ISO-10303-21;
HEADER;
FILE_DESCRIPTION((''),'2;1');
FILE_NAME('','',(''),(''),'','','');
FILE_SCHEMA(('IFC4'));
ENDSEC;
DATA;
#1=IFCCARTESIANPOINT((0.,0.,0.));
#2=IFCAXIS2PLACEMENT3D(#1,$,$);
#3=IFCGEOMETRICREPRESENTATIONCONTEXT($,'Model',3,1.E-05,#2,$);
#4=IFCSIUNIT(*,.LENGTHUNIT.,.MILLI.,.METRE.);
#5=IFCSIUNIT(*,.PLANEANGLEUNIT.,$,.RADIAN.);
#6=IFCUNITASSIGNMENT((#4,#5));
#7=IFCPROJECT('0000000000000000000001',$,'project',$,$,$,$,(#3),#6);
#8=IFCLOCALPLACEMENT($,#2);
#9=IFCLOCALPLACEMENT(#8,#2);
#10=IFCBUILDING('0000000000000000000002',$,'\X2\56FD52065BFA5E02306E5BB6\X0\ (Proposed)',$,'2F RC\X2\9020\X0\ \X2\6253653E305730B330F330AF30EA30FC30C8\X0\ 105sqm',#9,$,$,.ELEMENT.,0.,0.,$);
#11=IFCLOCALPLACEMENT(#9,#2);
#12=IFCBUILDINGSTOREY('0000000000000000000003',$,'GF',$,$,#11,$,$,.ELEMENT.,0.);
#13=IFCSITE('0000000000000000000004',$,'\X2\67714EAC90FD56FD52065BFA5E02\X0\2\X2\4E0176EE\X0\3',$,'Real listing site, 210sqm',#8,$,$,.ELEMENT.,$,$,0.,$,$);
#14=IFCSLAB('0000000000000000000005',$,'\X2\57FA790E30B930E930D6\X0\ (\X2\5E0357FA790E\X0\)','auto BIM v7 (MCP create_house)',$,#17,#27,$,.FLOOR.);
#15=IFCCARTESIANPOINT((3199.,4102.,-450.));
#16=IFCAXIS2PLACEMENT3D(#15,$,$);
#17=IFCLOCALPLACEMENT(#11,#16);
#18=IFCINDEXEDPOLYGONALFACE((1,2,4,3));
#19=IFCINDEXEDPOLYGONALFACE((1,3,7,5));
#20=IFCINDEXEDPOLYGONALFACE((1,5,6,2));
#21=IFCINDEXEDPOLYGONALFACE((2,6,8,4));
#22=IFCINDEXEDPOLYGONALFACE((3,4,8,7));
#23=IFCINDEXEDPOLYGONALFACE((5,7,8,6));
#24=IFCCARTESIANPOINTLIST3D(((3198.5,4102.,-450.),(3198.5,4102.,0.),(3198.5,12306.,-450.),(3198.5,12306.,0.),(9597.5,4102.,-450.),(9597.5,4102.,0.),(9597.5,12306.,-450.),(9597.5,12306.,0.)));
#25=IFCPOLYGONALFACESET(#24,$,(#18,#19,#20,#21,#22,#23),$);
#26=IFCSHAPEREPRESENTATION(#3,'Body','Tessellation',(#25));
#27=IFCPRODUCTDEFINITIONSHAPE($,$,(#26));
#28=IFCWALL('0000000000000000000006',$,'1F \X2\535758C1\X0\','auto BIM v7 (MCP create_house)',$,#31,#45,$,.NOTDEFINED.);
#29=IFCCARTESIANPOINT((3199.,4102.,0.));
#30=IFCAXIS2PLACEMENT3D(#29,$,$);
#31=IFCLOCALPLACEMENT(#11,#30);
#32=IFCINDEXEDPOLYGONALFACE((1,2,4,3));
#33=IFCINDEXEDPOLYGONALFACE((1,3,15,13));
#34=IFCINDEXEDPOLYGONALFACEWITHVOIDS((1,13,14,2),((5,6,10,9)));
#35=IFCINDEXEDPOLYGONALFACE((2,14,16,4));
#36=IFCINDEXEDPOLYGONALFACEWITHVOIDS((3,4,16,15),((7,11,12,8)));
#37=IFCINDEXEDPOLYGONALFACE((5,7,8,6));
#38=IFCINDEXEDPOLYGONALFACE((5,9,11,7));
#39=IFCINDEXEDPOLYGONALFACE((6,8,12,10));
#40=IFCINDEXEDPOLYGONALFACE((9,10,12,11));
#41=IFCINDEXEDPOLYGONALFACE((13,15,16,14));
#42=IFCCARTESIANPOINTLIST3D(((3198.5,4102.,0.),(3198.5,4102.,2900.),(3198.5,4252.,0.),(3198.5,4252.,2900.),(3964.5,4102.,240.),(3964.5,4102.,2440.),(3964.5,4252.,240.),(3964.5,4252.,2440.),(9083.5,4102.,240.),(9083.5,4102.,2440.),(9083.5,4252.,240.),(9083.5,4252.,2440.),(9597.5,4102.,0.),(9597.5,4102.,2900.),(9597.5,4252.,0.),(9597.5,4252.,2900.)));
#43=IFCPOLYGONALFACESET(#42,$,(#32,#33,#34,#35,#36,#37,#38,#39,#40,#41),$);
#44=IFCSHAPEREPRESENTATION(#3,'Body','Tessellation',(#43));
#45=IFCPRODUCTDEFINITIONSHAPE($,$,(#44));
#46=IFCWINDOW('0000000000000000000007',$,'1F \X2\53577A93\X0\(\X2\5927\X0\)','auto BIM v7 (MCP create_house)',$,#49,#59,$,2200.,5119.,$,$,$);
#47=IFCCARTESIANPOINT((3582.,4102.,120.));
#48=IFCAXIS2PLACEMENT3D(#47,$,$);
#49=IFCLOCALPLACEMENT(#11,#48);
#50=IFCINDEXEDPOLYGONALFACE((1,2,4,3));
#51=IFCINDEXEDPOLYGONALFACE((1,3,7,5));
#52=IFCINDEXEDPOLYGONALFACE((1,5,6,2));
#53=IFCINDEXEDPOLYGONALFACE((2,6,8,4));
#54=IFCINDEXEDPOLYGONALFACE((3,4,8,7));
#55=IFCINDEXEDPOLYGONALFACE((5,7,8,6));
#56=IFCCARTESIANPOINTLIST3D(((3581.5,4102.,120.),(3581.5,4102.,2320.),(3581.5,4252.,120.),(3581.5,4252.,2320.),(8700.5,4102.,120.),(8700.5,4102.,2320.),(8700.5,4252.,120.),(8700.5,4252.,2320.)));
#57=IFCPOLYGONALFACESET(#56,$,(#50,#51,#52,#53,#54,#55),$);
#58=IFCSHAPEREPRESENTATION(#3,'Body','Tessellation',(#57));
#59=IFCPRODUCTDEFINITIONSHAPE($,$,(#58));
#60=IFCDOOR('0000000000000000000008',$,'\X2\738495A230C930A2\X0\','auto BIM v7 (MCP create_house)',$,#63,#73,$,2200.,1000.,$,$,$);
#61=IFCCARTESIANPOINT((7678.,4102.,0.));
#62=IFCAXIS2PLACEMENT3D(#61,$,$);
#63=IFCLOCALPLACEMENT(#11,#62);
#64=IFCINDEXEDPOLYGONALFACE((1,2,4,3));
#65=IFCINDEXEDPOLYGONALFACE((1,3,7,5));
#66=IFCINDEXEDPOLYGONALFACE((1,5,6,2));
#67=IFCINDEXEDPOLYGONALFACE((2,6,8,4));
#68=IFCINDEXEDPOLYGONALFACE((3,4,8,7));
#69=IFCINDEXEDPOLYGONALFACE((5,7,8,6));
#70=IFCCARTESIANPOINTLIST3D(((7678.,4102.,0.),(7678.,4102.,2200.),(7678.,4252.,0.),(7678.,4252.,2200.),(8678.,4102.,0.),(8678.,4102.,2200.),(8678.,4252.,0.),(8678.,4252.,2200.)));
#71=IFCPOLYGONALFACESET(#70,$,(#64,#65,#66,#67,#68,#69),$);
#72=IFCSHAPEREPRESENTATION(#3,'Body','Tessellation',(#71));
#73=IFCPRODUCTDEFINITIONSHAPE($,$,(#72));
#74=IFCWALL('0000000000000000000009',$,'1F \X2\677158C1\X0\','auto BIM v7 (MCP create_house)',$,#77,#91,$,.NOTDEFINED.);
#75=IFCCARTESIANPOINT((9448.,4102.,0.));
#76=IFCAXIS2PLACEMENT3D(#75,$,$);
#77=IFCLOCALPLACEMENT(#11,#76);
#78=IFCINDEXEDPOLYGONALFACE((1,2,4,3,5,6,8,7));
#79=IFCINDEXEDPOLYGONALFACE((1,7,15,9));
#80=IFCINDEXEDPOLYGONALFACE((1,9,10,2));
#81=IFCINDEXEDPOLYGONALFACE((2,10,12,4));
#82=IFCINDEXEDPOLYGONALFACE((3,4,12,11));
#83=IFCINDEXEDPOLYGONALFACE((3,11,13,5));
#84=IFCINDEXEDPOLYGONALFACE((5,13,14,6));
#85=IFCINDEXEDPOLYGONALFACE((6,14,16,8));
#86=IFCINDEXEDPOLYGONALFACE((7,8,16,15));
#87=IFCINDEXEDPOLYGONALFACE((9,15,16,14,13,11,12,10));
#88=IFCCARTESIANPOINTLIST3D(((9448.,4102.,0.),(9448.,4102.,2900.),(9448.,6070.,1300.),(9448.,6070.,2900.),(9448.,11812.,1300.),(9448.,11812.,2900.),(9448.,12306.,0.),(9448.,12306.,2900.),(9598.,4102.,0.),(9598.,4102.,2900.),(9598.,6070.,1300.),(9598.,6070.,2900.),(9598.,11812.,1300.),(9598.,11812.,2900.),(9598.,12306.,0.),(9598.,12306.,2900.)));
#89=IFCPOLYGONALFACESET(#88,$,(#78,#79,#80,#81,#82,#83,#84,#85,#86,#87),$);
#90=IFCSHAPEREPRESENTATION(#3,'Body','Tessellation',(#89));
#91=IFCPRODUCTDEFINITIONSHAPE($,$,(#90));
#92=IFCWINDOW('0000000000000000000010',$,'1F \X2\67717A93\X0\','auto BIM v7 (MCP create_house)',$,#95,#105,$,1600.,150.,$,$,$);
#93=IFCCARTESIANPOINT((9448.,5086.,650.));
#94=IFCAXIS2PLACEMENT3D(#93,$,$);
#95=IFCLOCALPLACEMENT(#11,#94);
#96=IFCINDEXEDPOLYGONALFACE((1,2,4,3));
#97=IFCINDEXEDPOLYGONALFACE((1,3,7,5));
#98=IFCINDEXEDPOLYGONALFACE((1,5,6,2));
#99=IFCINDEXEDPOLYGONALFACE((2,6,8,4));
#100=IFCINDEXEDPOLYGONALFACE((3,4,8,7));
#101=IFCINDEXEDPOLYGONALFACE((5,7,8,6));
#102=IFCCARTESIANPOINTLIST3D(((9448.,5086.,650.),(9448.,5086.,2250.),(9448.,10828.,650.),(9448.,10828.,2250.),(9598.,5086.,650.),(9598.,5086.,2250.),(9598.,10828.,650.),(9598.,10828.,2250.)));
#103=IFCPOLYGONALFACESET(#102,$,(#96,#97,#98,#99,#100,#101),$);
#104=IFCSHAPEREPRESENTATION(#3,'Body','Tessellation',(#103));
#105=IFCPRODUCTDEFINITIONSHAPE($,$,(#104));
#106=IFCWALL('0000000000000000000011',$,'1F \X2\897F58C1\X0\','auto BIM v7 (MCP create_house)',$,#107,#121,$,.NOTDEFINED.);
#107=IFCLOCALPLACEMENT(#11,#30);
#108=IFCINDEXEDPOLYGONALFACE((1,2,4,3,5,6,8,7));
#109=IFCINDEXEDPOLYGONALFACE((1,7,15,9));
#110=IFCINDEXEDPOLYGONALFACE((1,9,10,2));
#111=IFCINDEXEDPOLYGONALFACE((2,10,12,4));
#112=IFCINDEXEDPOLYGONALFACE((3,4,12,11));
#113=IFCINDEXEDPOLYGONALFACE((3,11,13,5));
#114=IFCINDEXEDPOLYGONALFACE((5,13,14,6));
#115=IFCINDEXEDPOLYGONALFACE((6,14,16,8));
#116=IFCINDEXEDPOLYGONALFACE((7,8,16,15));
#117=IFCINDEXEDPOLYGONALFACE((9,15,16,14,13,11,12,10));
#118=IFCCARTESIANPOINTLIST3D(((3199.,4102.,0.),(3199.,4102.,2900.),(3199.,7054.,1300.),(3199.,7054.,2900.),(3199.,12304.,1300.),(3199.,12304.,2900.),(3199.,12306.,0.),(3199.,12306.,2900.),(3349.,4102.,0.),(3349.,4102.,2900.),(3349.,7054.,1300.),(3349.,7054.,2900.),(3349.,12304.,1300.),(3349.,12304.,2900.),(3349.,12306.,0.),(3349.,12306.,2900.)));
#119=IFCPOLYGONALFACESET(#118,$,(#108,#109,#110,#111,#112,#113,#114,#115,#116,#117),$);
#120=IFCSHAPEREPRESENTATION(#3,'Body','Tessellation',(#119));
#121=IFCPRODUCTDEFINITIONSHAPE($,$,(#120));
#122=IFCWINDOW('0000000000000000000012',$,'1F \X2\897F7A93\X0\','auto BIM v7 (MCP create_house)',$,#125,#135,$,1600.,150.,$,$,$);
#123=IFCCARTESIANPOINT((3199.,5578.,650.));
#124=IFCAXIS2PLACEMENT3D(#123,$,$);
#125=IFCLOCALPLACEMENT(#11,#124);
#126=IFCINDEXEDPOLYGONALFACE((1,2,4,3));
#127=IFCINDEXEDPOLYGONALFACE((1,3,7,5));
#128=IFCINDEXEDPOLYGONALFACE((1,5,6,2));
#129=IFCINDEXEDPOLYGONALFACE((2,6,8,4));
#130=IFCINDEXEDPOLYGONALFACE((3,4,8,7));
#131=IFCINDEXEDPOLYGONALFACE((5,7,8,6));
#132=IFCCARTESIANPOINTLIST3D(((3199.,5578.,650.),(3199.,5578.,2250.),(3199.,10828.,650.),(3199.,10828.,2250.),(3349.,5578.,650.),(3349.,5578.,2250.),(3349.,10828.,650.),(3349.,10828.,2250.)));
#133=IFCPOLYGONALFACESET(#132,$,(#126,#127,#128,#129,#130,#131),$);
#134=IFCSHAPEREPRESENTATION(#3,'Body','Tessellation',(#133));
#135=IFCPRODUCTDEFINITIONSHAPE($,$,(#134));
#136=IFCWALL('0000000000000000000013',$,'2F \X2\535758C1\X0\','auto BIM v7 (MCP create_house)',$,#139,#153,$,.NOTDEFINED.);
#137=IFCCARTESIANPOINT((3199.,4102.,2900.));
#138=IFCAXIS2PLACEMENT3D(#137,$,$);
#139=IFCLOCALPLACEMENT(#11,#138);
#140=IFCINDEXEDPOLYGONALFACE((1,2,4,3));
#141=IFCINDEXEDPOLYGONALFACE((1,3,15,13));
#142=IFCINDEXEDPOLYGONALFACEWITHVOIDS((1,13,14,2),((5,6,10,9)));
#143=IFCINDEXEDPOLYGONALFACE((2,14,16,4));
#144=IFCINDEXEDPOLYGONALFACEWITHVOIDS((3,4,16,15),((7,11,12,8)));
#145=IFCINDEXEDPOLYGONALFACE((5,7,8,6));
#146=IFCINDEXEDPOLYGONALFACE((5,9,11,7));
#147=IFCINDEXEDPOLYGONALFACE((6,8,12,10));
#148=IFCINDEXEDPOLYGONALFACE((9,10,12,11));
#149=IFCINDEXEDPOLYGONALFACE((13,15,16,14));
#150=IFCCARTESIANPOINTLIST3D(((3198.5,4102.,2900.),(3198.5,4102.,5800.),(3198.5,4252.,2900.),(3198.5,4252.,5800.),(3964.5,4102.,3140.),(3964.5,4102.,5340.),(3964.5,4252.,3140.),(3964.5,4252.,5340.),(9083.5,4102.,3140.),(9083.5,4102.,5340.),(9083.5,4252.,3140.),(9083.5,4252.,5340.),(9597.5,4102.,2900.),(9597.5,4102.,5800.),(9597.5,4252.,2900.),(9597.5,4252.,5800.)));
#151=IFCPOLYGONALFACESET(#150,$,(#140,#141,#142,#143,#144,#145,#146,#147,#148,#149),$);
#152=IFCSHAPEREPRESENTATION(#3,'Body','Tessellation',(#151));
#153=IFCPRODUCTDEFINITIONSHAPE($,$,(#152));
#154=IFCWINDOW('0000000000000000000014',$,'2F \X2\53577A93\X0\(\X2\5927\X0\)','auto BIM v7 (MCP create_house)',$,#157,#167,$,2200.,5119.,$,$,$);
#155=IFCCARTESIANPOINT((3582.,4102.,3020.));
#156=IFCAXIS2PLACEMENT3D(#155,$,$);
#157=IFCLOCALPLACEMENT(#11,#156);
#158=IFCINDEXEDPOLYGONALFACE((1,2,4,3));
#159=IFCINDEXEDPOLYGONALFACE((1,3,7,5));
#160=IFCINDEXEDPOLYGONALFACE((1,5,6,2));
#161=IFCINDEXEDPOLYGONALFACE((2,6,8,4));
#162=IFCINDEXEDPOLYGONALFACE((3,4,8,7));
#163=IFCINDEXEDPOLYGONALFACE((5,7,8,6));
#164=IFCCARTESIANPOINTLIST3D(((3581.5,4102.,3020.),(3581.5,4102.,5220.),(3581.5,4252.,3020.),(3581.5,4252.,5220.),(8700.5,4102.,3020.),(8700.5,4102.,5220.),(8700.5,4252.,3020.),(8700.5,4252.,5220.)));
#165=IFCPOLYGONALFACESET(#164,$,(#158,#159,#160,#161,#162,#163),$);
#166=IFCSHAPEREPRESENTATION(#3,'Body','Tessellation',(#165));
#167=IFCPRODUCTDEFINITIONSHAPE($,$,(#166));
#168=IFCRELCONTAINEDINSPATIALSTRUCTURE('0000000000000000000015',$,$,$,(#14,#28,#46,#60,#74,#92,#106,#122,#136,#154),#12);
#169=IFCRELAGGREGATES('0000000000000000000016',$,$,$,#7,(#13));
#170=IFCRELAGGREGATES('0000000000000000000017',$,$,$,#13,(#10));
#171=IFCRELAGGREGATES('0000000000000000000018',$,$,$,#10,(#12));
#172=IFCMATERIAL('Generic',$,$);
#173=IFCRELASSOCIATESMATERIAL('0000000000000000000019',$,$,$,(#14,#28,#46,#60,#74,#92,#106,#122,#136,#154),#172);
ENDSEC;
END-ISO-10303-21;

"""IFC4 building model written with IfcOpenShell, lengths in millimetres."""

from ifc_helpers import new_model, si_unit, frame, frame_2d, origin, place, context, project, spatial, rectangle, extrude, material, element, fill, save


model = new_model("IFC4")

# Units and contexts
model_context = context("Model", 3, precision=1e-05, world=origin())
ifc_project = project(units=[si_unit("LENGTHUNIT", "METRE", prefix="MILLI"), si_unit("PLANEANGLEUNIT", "RADIAN")], contexts=[model_context])

# Site, building, storey
site_placement = place(None, origin())
site = spatial("IfcSite", under=ifc_project, at=site_placement, Name="東京都国分寺市2丁目3", ObjectType="Real listing site, 210sqm", CompositionType="ELEMENT", RefElevation=0.0)
building_placement = place(site_placement, origin())
building = spatial("IfcBuilding", under=site, at=building_placement, Name="国分寺市の家 (Proposed)", ObjectType="2F RC造 打放しコンクリート 105sqm", CompositionType="ELEMENT", ElevationOfRefHeight=0.0, ElevationOfTerrain=0.0)
storey_placement = place(building_placement, origin())
storey = spatial("IfcBuildingStorey", under=building, at=storey_placement, Name="GF", CompositionType="ELEMENT", Elevation=0.0)

# Slab
ifc_material = material(Name="Generic")
slab_1_placement = place(storey_placement, frame((3199.0, 4102.0, -450.0)))
element("IfcSlab", 1, at=slab_1_placement, inside=storey, material=ifc_material, Name="基礎スラブ (布基礎)", Description="auto BIM v7 (MCP create_house)", PredefinedType="FLOOR", context=model_context, shape_type="SweptSolid", body=[
    extrude(rectangle(XDim=6399.0, YDim=8204.0, at=frame_2d((3199.0, 4102.0))), frame((3199.0, 4102.0, -450.0)), (0.0, 0.0, 1.0), 450.0),
])

# Wall, openings, window, door
wall_1_placement = place(storey_placement, frame((3199.0, 4102.0, 0.0)))
wall_1 = element("IfcWall", 2, at=wall_1_placement, inside=storey, material=ifc_material, Name="1F 南壁", Description="auto BIM v7 (MCP create_house)", PredefinedType="NOTDEFINED", context=model_context, shape_type="SweptSolid", body=[
    extrude(rectangle(XDim=6399.0, YDim=150.0, at=frame_2d((3199.0, 75.0))), frame((3199.0, 4102.0, 0.0)), (0.0, 0.0, 1.0), 2900.0),
])
opening_1_placement = place(storey_placement, frame((3582.0, 4102.0, 120.0)))
opening_1 = element("IfcOpeningElement", 3, at=opening_1_placement, cuts=wall_1, PredefinedType="NOTDEFINED", context=model_context, shape_type="SweptSolid", body=[
    extrude(rectangle(XDim=5119.0, YDim=150.0, at=frame_2d((2559.0, 75.0))), frame((3582.0, 4102.0, 120.0)), (0.0, 0.0, 1.0), 2200.0),
])
opening_2_placement = place(storey_placement, frame((7678.0, 4102.0, 0.0)))
opening_2 = element("IfcOpeningElement", 4, at=opening_2_placement, cuts=wall_1, PredefinedType="NOTDEFINED", context=model_context, shape_type="SweptSolid", body=[
    extrude(rectangle(XDim=1000.0, YDim=150.0, at=frame_2d((500.0, 75.0))), frame((7678.0, 4102.0, 0.0)), (0.0, 0.0, 1.0), 2200.0),
])
window_1_placement = place(storey_placement, frame((3582.0, 4102.0, 120.0)))
window_1 = element("IfcWindow", 5, at=window_1_placement, inside=storey, material=ifc_material, Name="1F 南窓(大)", Description="auto BIM v7 (MCP create_house)", OverallHeight=2200.0, OverallWidth=5119.0, context=model_context, shape_type="SweptSolid", body=[
    extrude(rectangle(XDim=5119.0, YDim=150.0, at=frame_2d((2559.0, 75.0))), frame((3582.0, 4102.0, 120.0)), (0.0, 0.0, 1.0), 2200.0),
])
fill(opening_1, window_1)
door_placement = place(storey_placement, frame((7678.0, 4102.0, 0.0)))
door = element("IfcDoor", 6, at=door_placement, inside=storey, material=ifc_material, Name="玄関ドア", Description="auto BIM v7 (MCP create_house)", OverallHeight=2200.0, OverallWidth=1000.0, context=model_context, shape_type="SweptSolid", body=[
    extrude(rectangle(XDim=1000.0, YDim=150.0, at=frame_2d((500.0, 75.0))), frame((7678.0, 4102.0, 0.0)), (0.0, 0.0, 1.0), 2200.0),
])
fill(opening_2, door)

# Walls, openings, windows
wall_2_placement = place(storey_placement, frame((9448.0, 4102.0, 0.0)))
wall_2 = element("IfcWall", 7, at=wall_2_placement, inside=storey, material=ifc_material, Name="1F 東壁", Description="auto BIM v7 (MCP create_house)", PredefinedType="NOTDEFINED", context=model_context, shape_type="SweptSolid", body=[
    extrude(rectangle(XDim=150.0, YDim=8204.0, at=frame_2d((75.0, 4102.0))), frame((9448.0, 4102.0, 0.0)), (0.0, 0.0, 1.0), 2900.0),
])
opening_3_placement = place(storey_placement, frame((9448.0, 5086.0, 650.0)))
opening_3 = element("IfcOpeningElement", 8, at=opening_3_placement, cuts=wall_2, PredefinedType="NOTDEFINED", context=model_context, shape_type="SweptSolid", body=[
    extrude(rectangle(XDim=150.0, YDim=5742.0, at=frame_2d((75.0, 2871.0))), frame((9448.0, 5086.0, 650.0)), (0.0, 0.0, 1.0), 1600.0),
])
window_2_placement = place(storey_placement, frame((9448.0, 5086.0, 650.0)))
window_2 = element("IfcWindow", 9, at=window_2_placement, inside=storey, material=ifc_material, Name="1F 東窓", Description="auto BIM v7 (MCP create_house)", OverallHeight=1600.0, OverallWidth=150.0, context=model_context, shape_type="SweptSolid", body=[
    extrude(rectangle(XDim=150.0, YDim=5742.0, at=frame_2d((75.0, 2871.0))), frame((9448.0, 5086.0, 650.0)), (0.0, 0.0, 1.0), 1600.0),
])
fill(opening_3, window_2)
wall_3_placement = place(storey_placement, frame((3199.0, 4102.0, 0.0)))
wall_3 = element("IfcWall", 10, at=wall_3_placement, inside=storey, material=ifc_material, Name="1F 西壁", Description="auto BIM v7 (MCP create_house)", PredefinedType="NOTDEFINED", context=model_context, shape_type="SweptSolid", body=[
    extrude(rectangle(XDim=150.0, YDim=8204.0, at=frame_2d((75.0, 4102.0))), frame((3199.0, 4102.0, 0.0)), (0.0, 0.0, 1.0), 2900.0),
])
opening_4_placement = place(storey_placement, frame((3199.0, 5578.0, 650.0)))
opening_4 = element("IfcOpeningElement", 11, at=opening_4_placement, cuts=wall_3, PredefinedType="NOTDEFINED", context=model_context, shape_type="SweptSolid", body=[
    extrude(rectangle(XDim=150.0, YDim=5250.0, at=frame_2d((75.0, 2625.0))), frame((3199.0, 5578.0, 650.0)), (0.0, 0.0, 1.0), 1600.0),
])
window_3_placement = place(storey_placement, frame((3199.0, 5578.0, 650.0)))
window_3 = element("IfcWindow", 12, at=window_3_placement, inside=storey, material=ifc_material, Name="1F 西窓", Description="auto BIM v7 (MCP create_house)", OverallHeight=1600.0, OverallWidth=150.0, context=model_context, shape_type="SweptSolid", body=[
    extrude(rectangle(XDim=150.0, YDim=5250.0, at=frame_2d((75.0, 2625.0))), frame((3199.0, 5578.0, 650.0)), (0.0, 0.0, 1.0), 1600.0),
])
fill(opening_4, window_3)

# Wall, opening, window
wall_4_placement = place(storey_placement, frame((3199.0, 4102.0, 2900.0)))
wall_4 = element("IfcWall", 13, at=wall_4_placement, inside=storey, material=ifc_material, Name="2F 南壁", Description="auto BIM v7 (MCP create_house)", PredefinedType="NOTDEFINED", context=model_context, shape_type="SweptSolid", body=[
    extrude(rectangle(XDim=6399.0, YDim=150.0, at=frame_2d((3199.0, 75.0))), frame((3199.0, 4102.0, 2900.0)), (0.0, 0.0, 1.0), 2900.0),
])
opening_5_placement = place(storey_placement, frame((3582.0, 4102.0, 3020.0)))
opening_5 = element("IfcOpeningElement", 14, at=opening_5_placement, cuts=wall_4, PredefinedType="NOTDEFINED", context=model_context, shape_type="SweptSolid", body=[
    extrude(rectangle(XDim=5119.0, YDim=150.0, at=frame_2d((2559.0, 75.0))), frame((3582.0, 4102.0, 3020.0)), (0.0, 0.0, 1.0), 2200.0),
])
window_4_placement = place(storey_placement, frame((3582.0, 4102.0, 3020.0)))
window_4 = element("IfcWindow", 15, at=window_4_placement, inside=storey, material=ifc_material, Name="2F 南窓(大)", Description="auto BIM v7 (MCP create_house)", OverallHeight=2200.0, OverallWidth=5119.0, context=model_context, shape_type="SweptSolid", body=[
    extrude(rectangle(XDim=5119.0, YDim=150.0, at=frame_2d((2559.0, 75.0))), frame((3582.0, 4102.0, 3020.0)), (0.0, 0.0, 1.0), 2200.0),
])
fill(opening_5, window_4)

save(model, "model.ifc")
